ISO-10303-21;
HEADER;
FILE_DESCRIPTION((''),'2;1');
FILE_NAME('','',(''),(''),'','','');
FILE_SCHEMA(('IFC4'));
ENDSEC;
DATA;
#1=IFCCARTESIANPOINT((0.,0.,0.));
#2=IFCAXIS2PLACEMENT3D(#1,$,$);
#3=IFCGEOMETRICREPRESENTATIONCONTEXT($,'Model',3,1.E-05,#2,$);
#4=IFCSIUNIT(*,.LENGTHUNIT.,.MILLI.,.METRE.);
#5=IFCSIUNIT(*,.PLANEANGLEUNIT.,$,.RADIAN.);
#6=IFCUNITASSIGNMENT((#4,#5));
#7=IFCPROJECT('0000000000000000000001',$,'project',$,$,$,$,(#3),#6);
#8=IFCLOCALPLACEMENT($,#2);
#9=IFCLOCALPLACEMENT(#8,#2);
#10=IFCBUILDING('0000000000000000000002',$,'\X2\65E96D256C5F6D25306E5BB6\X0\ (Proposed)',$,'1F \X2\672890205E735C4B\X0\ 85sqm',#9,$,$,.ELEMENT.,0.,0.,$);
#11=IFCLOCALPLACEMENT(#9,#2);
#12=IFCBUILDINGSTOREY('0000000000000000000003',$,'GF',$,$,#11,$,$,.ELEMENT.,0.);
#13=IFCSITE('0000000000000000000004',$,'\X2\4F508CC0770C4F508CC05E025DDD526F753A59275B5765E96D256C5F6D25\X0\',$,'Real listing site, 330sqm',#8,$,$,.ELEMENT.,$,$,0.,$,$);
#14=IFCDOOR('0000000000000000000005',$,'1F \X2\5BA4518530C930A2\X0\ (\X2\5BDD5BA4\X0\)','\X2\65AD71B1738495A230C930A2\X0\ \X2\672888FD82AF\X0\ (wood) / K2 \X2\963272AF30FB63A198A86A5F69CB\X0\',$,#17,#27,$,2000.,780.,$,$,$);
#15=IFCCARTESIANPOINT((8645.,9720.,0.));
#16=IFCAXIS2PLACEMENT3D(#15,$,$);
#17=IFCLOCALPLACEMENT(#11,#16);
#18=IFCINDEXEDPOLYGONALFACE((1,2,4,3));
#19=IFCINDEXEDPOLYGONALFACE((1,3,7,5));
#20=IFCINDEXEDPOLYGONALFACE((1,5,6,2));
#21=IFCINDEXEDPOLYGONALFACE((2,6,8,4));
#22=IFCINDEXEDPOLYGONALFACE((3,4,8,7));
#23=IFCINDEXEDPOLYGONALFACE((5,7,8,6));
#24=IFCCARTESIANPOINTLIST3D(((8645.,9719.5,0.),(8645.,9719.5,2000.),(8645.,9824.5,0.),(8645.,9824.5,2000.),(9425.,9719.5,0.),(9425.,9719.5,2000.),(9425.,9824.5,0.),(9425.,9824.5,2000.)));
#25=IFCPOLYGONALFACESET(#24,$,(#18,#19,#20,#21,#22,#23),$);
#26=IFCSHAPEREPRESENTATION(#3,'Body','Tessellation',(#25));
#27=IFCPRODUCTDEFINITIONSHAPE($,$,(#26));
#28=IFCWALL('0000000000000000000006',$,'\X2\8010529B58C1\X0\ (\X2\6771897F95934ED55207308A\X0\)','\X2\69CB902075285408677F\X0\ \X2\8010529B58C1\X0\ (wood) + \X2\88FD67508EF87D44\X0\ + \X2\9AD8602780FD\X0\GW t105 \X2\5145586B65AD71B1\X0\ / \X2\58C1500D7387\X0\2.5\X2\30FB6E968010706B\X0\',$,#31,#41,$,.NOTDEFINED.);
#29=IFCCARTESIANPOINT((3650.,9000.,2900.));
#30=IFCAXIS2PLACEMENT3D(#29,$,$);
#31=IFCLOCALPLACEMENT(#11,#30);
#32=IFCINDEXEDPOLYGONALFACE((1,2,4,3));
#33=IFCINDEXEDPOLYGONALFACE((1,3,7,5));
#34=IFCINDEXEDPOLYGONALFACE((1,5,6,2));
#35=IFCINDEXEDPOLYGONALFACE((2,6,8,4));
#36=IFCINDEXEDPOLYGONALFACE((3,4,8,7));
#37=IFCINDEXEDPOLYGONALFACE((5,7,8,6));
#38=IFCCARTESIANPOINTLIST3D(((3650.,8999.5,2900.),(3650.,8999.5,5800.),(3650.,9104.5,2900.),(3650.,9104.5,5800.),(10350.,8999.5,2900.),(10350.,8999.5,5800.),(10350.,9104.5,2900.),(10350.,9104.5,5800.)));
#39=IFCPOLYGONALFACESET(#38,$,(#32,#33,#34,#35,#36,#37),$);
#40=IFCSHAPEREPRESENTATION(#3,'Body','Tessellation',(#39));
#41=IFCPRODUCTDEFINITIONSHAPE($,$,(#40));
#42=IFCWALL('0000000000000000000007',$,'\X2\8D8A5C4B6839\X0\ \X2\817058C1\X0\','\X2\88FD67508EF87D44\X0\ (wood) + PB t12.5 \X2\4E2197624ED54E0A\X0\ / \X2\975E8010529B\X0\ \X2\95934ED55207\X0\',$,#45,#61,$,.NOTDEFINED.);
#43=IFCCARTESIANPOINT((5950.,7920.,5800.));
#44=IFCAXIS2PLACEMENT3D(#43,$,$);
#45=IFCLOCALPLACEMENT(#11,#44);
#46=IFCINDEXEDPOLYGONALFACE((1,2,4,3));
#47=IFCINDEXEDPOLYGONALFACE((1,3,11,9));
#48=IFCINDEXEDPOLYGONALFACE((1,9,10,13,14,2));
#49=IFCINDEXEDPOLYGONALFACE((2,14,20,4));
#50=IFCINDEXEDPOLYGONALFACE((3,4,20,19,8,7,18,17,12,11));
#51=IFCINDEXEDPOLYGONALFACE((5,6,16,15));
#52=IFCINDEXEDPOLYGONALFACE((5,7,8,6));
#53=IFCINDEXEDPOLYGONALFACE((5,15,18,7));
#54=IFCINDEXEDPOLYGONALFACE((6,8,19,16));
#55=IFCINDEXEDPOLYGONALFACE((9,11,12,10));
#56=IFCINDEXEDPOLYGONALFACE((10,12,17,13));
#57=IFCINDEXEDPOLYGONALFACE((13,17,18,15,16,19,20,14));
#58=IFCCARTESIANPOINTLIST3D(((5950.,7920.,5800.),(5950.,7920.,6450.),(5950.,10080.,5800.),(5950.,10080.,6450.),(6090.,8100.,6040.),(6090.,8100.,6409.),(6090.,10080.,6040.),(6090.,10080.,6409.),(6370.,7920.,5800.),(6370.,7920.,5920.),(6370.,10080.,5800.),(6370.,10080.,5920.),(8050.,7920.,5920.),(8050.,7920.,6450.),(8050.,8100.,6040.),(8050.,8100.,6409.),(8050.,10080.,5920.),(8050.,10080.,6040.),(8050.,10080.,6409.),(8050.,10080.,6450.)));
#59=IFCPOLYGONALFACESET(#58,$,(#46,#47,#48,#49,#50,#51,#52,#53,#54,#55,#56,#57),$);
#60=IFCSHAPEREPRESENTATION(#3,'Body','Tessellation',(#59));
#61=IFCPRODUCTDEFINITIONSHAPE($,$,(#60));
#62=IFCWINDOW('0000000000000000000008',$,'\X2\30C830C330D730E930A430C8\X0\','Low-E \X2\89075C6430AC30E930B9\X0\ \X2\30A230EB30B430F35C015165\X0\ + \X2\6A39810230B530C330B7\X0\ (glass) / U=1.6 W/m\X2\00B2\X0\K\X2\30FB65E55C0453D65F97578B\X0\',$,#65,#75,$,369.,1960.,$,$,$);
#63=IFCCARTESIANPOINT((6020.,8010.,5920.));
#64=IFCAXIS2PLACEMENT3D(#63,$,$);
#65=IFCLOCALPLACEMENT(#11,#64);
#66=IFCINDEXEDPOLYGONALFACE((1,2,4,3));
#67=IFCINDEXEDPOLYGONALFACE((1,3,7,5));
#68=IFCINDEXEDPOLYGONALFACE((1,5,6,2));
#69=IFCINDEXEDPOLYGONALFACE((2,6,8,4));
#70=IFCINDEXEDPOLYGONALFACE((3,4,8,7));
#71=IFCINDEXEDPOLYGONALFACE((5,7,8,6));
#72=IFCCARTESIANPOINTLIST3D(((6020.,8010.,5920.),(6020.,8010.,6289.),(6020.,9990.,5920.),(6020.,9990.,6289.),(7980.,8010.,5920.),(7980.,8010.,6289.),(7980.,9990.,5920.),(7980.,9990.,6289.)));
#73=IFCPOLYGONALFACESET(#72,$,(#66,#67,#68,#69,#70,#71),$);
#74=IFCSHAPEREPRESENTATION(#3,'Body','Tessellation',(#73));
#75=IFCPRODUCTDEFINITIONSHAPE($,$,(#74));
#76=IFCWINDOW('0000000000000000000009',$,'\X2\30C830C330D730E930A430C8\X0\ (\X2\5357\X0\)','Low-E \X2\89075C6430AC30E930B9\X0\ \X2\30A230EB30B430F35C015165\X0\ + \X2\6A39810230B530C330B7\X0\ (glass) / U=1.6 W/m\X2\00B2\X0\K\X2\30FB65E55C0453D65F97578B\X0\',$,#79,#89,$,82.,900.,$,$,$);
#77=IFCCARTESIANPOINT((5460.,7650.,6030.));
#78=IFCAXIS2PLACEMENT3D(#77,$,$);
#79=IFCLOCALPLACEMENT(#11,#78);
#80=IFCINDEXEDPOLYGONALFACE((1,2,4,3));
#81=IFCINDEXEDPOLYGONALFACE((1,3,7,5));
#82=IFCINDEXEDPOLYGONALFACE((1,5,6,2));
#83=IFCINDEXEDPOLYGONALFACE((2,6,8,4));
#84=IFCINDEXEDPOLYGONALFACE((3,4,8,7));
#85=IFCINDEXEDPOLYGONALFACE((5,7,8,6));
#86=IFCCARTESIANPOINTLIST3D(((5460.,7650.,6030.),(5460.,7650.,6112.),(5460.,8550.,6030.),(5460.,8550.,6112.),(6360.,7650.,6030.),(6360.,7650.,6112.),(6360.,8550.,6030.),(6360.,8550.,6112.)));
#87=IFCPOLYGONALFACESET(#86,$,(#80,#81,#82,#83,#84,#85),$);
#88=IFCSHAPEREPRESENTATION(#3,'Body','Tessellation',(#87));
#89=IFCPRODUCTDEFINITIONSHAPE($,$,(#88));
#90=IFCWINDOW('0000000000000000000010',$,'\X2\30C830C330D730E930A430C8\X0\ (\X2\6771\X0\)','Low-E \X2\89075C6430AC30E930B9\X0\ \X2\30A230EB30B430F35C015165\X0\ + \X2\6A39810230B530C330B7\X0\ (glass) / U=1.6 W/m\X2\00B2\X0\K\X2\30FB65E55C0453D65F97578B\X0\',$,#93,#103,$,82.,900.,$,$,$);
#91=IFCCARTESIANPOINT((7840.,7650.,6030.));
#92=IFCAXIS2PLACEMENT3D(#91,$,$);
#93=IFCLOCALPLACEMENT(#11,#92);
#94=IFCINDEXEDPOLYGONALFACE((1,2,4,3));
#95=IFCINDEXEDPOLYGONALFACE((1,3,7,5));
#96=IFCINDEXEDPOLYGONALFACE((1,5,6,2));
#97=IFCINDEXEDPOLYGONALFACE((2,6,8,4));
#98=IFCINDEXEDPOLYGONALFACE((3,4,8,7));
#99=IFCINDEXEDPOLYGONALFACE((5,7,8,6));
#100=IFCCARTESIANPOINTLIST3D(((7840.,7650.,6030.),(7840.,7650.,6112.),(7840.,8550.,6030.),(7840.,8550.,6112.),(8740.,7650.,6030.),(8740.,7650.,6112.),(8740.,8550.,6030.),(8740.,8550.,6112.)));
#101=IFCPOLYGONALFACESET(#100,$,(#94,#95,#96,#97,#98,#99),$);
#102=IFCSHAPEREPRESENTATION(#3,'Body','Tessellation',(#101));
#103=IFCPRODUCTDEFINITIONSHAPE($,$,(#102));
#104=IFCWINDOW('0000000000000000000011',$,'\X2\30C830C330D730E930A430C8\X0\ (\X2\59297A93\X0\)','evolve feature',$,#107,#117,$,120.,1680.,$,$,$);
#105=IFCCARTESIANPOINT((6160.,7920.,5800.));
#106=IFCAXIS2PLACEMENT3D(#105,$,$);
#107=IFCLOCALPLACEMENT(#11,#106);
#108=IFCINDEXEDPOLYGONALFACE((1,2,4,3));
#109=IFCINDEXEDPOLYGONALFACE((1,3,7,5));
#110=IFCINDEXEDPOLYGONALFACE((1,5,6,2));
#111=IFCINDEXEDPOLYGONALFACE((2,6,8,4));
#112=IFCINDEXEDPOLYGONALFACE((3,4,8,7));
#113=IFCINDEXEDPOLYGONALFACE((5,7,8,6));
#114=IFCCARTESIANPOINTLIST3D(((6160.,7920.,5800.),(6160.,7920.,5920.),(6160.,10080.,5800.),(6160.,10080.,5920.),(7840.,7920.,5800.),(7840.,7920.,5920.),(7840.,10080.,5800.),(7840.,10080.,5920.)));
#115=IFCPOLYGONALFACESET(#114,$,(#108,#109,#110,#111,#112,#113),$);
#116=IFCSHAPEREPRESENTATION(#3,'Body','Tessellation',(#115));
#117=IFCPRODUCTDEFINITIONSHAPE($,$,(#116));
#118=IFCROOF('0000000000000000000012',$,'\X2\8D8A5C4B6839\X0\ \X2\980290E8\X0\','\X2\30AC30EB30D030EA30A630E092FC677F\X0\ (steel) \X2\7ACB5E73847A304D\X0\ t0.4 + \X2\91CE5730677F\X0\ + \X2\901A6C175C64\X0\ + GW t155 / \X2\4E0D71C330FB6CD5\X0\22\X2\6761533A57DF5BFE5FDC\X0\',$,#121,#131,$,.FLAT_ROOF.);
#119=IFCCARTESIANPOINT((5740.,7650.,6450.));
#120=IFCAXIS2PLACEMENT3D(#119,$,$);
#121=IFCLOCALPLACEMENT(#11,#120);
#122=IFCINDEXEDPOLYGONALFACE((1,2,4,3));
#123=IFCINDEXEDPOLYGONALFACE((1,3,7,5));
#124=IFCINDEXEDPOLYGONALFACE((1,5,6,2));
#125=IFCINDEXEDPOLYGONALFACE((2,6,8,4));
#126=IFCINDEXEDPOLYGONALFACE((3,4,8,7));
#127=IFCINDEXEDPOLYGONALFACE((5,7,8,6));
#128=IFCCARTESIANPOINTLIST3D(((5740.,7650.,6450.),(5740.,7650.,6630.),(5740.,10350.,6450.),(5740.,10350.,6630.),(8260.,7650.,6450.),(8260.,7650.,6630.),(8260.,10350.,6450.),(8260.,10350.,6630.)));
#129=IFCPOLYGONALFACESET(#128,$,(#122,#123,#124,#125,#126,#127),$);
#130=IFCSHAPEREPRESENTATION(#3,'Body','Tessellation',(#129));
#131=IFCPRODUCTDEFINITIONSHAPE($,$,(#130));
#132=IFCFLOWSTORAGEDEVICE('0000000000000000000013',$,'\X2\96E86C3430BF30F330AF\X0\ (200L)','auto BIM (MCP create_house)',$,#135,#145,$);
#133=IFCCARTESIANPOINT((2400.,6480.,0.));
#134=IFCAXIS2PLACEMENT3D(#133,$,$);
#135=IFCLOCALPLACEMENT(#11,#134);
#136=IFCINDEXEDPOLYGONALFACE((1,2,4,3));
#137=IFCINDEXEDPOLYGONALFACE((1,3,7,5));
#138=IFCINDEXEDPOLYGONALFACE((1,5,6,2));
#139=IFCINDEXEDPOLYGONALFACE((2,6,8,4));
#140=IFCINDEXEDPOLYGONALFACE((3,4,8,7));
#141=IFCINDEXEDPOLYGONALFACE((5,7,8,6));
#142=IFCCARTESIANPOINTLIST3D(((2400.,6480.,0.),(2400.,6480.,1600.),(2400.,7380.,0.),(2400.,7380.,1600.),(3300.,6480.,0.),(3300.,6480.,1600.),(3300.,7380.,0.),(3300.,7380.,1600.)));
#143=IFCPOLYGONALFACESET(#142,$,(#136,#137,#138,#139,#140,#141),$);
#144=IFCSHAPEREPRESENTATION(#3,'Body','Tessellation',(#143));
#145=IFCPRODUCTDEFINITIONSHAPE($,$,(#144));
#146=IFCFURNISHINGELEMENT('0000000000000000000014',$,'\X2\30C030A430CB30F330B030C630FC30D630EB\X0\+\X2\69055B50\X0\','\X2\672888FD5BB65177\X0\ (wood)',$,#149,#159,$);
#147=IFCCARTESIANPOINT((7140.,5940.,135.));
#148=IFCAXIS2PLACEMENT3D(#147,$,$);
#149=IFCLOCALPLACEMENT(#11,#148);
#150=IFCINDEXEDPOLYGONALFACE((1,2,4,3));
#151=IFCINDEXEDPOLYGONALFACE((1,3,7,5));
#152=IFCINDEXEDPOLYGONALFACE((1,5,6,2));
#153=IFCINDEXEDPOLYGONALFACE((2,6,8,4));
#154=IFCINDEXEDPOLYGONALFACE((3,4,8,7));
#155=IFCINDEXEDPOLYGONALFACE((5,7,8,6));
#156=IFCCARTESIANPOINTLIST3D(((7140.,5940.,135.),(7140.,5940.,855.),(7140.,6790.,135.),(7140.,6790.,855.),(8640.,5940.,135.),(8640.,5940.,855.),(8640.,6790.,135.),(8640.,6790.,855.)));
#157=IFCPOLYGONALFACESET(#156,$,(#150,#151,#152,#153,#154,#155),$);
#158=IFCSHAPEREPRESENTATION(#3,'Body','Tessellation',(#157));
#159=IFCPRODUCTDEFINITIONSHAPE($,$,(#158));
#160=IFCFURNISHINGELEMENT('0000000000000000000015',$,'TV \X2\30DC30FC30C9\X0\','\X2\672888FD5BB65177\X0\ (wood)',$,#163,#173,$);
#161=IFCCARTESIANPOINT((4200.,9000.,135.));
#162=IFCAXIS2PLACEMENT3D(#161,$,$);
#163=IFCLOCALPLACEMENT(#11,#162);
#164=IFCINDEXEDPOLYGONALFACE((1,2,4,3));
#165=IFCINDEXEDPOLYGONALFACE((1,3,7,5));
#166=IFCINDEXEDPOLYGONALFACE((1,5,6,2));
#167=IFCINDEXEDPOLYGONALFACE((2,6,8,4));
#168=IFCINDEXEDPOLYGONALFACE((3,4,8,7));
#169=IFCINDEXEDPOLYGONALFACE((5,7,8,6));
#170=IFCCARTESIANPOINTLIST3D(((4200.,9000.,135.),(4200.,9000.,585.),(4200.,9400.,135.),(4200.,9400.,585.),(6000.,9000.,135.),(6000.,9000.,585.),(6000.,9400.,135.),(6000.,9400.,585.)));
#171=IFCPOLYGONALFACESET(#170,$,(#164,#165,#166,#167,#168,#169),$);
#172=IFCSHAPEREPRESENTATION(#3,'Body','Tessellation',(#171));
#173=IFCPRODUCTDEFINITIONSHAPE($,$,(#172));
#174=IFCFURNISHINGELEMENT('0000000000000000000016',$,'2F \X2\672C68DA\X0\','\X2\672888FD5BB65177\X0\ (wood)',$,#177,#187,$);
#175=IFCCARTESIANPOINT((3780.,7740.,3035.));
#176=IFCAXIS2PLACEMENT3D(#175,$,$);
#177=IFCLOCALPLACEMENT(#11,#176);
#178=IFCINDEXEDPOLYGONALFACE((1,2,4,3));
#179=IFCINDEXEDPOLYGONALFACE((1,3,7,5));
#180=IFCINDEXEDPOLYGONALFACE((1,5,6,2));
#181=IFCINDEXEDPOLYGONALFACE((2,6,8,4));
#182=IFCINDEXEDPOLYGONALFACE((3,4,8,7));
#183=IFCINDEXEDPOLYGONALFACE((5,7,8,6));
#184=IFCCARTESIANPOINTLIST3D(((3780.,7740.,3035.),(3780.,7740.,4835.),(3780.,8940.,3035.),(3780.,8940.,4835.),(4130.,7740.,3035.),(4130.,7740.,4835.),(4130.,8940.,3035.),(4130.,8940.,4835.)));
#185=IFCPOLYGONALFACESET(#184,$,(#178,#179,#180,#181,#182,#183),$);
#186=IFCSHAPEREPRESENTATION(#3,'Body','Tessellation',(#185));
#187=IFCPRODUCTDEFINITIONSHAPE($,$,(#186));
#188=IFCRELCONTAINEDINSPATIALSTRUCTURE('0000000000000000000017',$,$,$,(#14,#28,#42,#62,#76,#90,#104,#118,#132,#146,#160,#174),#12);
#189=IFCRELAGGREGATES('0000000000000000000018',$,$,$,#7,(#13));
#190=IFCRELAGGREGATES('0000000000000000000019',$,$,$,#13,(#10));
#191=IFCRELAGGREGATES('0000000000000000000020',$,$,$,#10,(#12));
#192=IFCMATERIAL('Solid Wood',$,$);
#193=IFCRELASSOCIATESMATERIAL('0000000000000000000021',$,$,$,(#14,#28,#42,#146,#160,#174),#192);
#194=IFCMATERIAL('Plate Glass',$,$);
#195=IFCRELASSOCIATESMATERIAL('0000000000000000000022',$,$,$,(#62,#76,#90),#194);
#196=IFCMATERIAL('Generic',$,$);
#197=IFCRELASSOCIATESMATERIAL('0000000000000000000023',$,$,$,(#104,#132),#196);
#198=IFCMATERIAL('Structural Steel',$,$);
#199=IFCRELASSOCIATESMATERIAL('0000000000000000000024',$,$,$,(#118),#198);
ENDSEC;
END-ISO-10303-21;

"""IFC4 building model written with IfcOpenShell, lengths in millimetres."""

from ifc_helpers import new_model, si_unit, frame, frame_2d, origin, place, context, project, spatial, rectangle, extrude, material, element, fill, save


model = new_model("IFC4")

# Units and contexts
model_context = context("Model", 3, precision=1e-05, world=origin())
ifc_project = project(units=[si_unit("LENGTHUNIT", "METRE", prefix="MILLI"), si_unit("PLANEANGLEUNIT", "RADIAN")], contexts=[model_context])

# Site, building, storey
site_placement = place(None, origin())
site = spatial("IfcSite", under=ifc_project, at=site_placement, Name="佐賀県佐賀市川副町大字早津江津", ObjectType="Real listing site, 330sqm", CompositionType="ELEMENT", RefElevation=0.0)
building_placement = place(site_placement, origin())
building = spatial("IfcBuilding", under=site, at=building_placement, Name="早津江津の家 (Proposed)", ObjectType="1F 木造平屋 85sqm", CompositionType="ELEMENT", ElevationOfRefHeight=0.0, ElevationOfTerrain=0.0)
storey_placement = place(building_placement, origin())
storey = spatial("IfcBuildingStorey", under=building, at=storey_placement, Name="GF", CompositionType="ELEMENT", Elevation=0.0)

# Shared definitions
ifc_material_1 = material(Name="Solid Wood")

# Door
door_placement = place(storey_placement, frame((8645.0, 9720.0, 0.0)))
element("IfcDoor", 1, at=door_placement, inside=storey, material=ifc_material_1, Name="1F 室内ドア (寝室)", Description="断熱玄関ドア 木製芯 (wood) / K2 防犯・採風機構", OverallHeight=2000.0, OverallWidth=780.0, context=model_context, shape_type="SweptSolid", body=[
    extrude(rectangle(XDim=780.0, YDim=105.0, at=frame_2d((390.0, 52.0))), frame((8645.0, 9720.0, 0.0)), (0.0, 0.0, 1.0), 2000.0),
])

# Wall
wall_1_placement = place(storey_placement, frame((3650.0, 9000.0, 2900.0)))
element("IfcWall", 2, at=wall_1_placement, inside=storey, material=ifc_material_1, Name="耐力壁 (東西間仕切り)", Description="構造用合板 耐力壁 (wood) + 製材軸組 + 高性能GW t105 充填断熱 / 壁倍率2.5・準耐火", PredefinedType="NOTDEFINED", context=model_context, shape_type="SweptSolid", body=[
    extrude(rectangle(XDim=6700.0, YDim=105.0, at=frame_2d((3350.0, 52.0))), frame((3650.0, 9000.0, 2900.0)), (0.0, 0.0, 1.0), 2900.0),
])

# Wall, openings, windows
wall_2_placement = place(storey_placement, frame((5950.0, 7920.0, 5800.0)))
wall_2 = element("IfcWall", 3, at=wall_2_placement, inside=storey, material=ifc_material_1, Name="越屋根 腰壁", Description="製材軸組 (wood) + PB t12.5 両面仕上 / 非耐力 間仕切", PredefinedType="NOTDEFINED", context=model_context, shape_type="SweptSolid", body=[
    extrude(rectangle(XDim=2100.0, YDim=2160.0, at=frame_2d((1050.0, 1080.0))), frame((5950.0, 7920.0, 5800.0)), (0.0, 0.0, 1.0), 650.0),
])
opening_1_placement = place(storey_placement, frame((6020.0, 8010.0, 5920.0)))
opening_1 = element("IfcOpeningElement", 4, at=opening_1_placement, cuts=wall_2, PredefinedType="NOTDEFINED", context=model_context, shape_type="SweptSolid", body=[
    extrude(rectangle(XDim=1960.0, YDim=1980.0, at=frame_2d((980.0, 990.0))), frame((6020.0, 8010.0, 5920.0)), (0.0, 0.0, 1.0), 369.0),
])
opening_2_placement = place(storey_placement, frame((5460.0, 7650.0, 6030.0)))
opening_2 = element("IfcOpeningElement", 5, at=opening_2_placement, cuts=wall_2, PredefinedType="NOTDEFINED", context=model_context, shape_type="SweptSolid", body=[
    extrude(rectangle(XDim=900.0, YDim=900.0, at=frame_2d((450.0, 450.0))), frame((5460.0, 7650.0, 6030.0)), (0.0, 0.0, 1.0), 82.0),
])
opening_3_placement = place(storey_placement, frame((7840.0, 7650.0, 6030.0)))
opening_3 = element("IfcOpeningElement", 6, at=opening_3_placement, cuts=wall_2, PredefinedType="NOTDEFINED", context=model_context, shape_type="SweptSolid", body=[
    extrude(rectangle(XDim=900.0, YDim=900.0, at=frame_2d((450.0, 450.0))), frame((7840.0, 7650.0, 6030.0)), (0.0, 0.0, 1.0), 82.0),
])
opening_4_placement = place(storey_placement, frame((6160.0, 7920.0, 5800.0)))
opening_4 = element("IfcOpeningElement", 7, at=opening_4_placement, cuts=wall_2, PredefinedType="NOTDEFINED", context=model_context, shape_type="SweptSolid", body=[
    extrude(rectangle(XDim=1680.0, YDim=2160.0, at=frame_2d((840.0, 1080.0))), frame((6160.0, 7920.0, 5800.0)), (0.0, 0.0, 1.0), 120.0),
])
ifc_material_2 = material(Name="Plate Glass")
window_1_placement = place(storey_placement, frame((6020.0, 8010.0, 5920.0)))
window_1 = element("IfcWindow", 8, at=window_1_placement, inside=storey, material=ifc_material_2, Name="トップライト", Description="Low-E 複層ガラス アルゴン封入 + 樹脂サッシ (glass) / U=1.6 W/m²K・日射取得型", OverallHeight=369.0, OverallWidth=1960.0, context=model_context, shape_type="SweptSolid", body=[
    extrude(rectangle(XDim=1960.0, YDim=1980.0, at=frame_2d((980.0, 990.0))), frame((6020.0, 8010.0, 5920.0)), (0.0, 0.0, 1.0), 369.0),
])
fill(opening_1, window_1)
window_2_placement = place(storey_placement, frame((5460.0, 7650.0, 6030.0)))
window_2 = element("IfcWindow", 9, at=window_2_placement, inside=storey, material=ifc_material_2, Name="トップライト (南)", Description="Low-E 複層ガラス アルゴン封入 + 樹脂サッシ (glass) / U=1.6 W/m²K・日射取得型", OverallHeight=82.0, OverallWidth=900.0, context=model_context, shape_type="SweptSolid", body=[
    extrude(rectangle(XDim=900.0, YDim=900.0, at=frame_2d((450.0, 450.0))), frame((5460.0, 7650.0, 6030.0)), (0.0, 0.0, 1.0), 82.0),
])
fill(opening_2, window_2)
window_3_placement = place(storey_placement, frame((7840.0, 7650.0, 6030.0)))
window_3 = element("IfcWindow", 10, at=window_3_placement, inside=storey, material=ifc_material_2, Name="トップライト (東)", Description="Low-E 複層ガラス アルゴン封入 + 樹脂サッシ (glass) / U=1.6 W/m²K・日射取得型", OverallHeight=82.0, OverallWidth=900.0, context=model_context, shape_type="SweptSolid", body=[
    extrude(rectangle(XDim=900.0, YDim=900.0, at=frame_2d((450.0, 450.0))), frame((7840.0, 7650.0, 6030.0)), (0.0, 0.0, 1.0), 82.0),
])
fill(opening_3, window_3)
ifc_material_3 = material(Name="Generic")
window_4_placement = place(storey_placement, frame((6160.0, 7920.0, 5800.0)))
window_4 = element("IfcWindow", 11, at=window_4_placement, inside=storey, material=ifc_material_3, Name="トップライト (天窓)", Description="evolve feature", OverallHeight=120.0, OverallWidth=1680.0, context=model_context, shape_type="SweptSolid", body=[
    extrude(rectangle(XDim=1680.0, YDim=2160.0, at=frame_2d((840.0, 1080.0))), frame((6160.0, 7920.0, 5800.0)), (0.0, 0.0, 1.0), 120.0),
])
fill(opening_4, window_4)

# Roof
ifc_material_4 = material(Name="Structural Steel")
roof_placement = place(storey_placement, frame((5740.0, 7650.0, 6450.0)))
element("IfcRoof", 12, at=roof_placement, inside=storey, material=ifc_material_4, Name="越屋根 頂部", Description="ガルバリウム鋼板 (steel) 立平葺き t0.4 + 野地板 + 通気層 + GW t155 / 不燃・法22条区域対応", PredefinedType="FLAT_ROOF", context=model_context, shape_type="SweptSolid", body=[
    extrude(rectangle(XDim=2520.0, YDim=2700.0, at=frame_2d((1260.0, 1350.0))), frame((5740.0, 7650.0, 6450.0)), (0.0, 0.0, 1.0), 180.0),
])

# Flow storage device
flow_storage_device_placement = place(storey_placement, frame((2400.0, 6480.0, 0.0)))
element("IfcFlowStorageDevice", 13, at=flow_storage_device_placement, inside=storey, material=ifc_material_3, Name="雨水タンク (200L)", Description="auto BIM (MCP create_house)", context=model_context, shape_type="SweptSolid", body=[
    extrude(rectangle(XDim=900.0, YDim=900.0, at=frame_2d((450.0, 450.0))), frame((2400.0, 6480.0, 0.0)), (0.0, 0.0, 1.0), 1600.0),
])

# Furnishing elements
furnishing_1_placement = place(storey_placement, frame((7140.0, 5940.0, 135.0)))
element("IfcFurnishingElement", 14, at=furnishing_1_placement, inside=storey, material=ifc_material_1, Name="ダイニングテーブル+椅子", Description="木製家具 (wood)", context=model_context, shape_type="SweptSolid", body=[
    extrude(rectangle(XDim=1500.0, YDim=850.0, at=frame_2d((750.0, 425.0))), frame((7140.0, 5940.0, 135.0)), (0.0, 0.0, 1.0), 720.0),
])
furnishing_2_placement = place(storey_placement, frame((4200.0, 9000.0, 135.0)))
element("IfcFurnishingElement", 15, at=furnishing_2_placement, inside=storey, material=ifc_material_1, Name="TV ボード", Description="木製家具 (wood)", context=model_context, shape_type="SweptSolid", body=[
    extrude(rectangle(XDim=1800.0, YDim=400.0, at=frame_2d((900.0, 200.0))), frame((4200.0, 9000.0, 135.0)), (0.0, 0.0, 1.0), 450.0),
])
furnishing_3_placement = place(storey_placement, frame((3780.0, 7740.0, 3035.0)))
element("IfcFurnishingElement", 16, at=furnishing_3_placement, inside=storey, material=ifc_material_1, Name="2F 本棚", Description="木製家具 (wood)", context=model_context, shape_type="SweptSolid", body=[
    extrude(rectangle(XDim=350.0, YDim=1200.0, at=frame_2d((175.0, 600.0))), frame((3780.0, 7740.0, 3035.0)), (0.0, 0.0, 1.0), 1800.0),
])

save(model, "model.ifc")
